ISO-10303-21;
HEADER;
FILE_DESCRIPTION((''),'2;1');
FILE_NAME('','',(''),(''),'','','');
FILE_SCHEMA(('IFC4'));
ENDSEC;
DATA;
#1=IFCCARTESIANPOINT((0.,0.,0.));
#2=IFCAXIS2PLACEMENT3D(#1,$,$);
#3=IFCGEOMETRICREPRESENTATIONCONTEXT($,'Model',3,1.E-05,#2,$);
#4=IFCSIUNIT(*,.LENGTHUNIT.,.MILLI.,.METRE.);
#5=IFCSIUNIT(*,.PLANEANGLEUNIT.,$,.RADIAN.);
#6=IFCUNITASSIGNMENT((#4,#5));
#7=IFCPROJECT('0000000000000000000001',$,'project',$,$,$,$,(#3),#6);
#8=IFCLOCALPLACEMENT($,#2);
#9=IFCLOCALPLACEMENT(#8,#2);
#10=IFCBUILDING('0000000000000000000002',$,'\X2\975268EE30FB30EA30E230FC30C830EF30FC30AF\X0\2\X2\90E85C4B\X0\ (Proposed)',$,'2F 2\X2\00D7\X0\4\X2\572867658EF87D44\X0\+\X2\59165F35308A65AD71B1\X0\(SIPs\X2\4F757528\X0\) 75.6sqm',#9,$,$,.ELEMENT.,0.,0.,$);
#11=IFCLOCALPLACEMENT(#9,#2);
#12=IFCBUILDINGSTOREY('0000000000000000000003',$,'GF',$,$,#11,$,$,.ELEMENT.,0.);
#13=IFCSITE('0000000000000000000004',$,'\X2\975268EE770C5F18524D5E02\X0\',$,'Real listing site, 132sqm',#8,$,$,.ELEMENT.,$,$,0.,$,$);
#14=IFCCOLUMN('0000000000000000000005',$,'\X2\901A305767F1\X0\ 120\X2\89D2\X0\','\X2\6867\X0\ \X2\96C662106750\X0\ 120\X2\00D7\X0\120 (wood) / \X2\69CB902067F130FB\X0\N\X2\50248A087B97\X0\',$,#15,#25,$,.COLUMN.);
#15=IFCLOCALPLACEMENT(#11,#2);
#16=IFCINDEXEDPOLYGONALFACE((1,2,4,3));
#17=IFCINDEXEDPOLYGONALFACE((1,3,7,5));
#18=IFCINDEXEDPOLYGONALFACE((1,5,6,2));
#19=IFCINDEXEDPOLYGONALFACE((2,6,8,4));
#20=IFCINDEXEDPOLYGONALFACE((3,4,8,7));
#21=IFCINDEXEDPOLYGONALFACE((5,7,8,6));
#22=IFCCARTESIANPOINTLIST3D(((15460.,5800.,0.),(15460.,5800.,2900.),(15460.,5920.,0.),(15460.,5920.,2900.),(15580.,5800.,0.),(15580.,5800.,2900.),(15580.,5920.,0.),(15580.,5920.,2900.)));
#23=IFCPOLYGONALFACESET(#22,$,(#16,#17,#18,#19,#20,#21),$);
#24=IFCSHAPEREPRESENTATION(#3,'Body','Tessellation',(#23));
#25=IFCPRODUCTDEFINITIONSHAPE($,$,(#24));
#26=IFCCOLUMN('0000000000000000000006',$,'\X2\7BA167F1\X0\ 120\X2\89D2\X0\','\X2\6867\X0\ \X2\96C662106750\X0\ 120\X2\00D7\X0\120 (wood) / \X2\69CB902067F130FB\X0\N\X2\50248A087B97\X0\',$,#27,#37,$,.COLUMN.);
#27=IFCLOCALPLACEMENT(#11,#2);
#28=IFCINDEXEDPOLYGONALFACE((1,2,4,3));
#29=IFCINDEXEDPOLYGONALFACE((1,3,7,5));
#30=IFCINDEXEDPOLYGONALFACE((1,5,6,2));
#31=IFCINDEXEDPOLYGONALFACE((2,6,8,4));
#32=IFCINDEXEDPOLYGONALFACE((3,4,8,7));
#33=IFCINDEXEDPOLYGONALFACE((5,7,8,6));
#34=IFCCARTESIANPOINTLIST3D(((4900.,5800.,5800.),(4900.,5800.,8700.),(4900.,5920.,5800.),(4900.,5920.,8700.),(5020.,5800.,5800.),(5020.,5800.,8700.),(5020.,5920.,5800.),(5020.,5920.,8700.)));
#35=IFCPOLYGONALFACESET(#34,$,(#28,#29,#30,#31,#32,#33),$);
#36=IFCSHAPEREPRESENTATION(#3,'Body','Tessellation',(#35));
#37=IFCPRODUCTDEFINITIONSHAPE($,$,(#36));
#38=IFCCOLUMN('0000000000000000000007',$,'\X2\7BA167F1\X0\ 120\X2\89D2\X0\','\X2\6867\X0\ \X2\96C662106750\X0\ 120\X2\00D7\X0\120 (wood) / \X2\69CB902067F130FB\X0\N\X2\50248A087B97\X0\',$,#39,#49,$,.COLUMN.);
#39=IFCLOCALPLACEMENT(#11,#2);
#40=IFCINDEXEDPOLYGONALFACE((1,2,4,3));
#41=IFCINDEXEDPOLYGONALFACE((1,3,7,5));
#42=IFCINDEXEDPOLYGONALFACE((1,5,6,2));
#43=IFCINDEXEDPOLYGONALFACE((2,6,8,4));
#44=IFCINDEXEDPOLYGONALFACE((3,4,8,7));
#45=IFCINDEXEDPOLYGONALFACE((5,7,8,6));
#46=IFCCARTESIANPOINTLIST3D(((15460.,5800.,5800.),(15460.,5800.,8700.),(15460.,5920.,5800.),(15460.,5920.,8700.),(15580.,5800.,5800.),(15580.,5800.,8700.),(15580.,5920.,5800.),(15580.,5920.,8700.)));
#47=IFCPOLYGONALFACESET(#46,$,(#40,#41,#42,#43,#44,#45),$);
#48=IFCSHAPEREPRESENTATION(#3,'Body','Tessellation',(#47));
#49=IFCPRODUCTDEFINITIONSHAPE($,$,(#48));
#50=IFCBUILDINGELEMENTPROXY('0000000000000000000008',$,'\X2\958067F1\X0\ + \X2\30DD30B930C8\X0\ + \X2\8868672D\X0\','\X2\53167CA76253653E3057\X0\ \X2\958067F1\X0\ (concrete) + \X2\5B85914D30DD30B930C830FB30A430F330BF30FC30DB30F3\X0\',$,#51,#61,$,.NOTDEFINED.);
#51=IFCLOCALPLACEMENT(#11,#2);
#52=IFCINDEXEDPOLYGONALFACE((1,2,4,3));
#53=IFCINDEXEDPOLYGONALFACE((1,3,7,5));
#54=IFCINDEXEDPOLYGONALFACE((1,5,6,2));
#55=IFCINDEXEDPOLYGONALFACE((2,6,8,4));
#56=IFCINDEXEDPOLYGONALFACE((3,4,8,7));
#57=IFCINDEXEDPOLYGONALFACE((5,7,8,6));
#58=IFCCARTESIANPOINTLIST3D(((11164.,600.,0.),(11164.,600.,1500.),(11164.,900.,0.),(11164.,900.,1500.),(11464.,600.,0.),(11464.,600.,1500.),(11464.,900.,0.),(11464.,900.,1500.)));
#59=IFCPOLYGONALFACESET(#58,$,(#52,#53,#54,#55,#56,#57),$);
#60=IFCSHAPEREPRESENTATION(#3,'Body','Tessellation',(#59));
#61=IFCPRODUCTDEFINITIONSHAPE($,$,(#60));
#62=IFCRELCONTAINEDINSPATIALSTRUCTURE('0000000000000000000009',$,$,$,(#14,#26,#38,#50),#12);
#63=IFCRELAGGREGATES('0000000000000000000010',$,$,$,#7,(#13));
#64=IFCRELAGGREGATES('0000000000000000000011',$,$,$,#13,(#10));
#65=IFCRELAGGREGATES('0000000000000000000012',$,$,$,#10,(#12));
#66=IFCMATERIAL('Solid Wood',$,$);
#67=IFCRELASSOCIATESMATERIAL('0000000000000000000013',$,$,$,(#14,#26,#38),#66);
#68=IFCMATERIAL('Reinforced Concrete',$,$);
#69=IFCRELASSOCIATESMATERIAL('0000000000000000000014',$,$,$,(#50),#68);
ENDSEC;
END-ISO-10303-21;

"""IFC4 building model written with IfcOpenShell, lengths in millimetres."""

from ifc_helpers import new_model, si_unit, frame, frame_2d, origin, place, context, project, spatial, rectangle, extrude, material, element, save


model = new_model("IFC4")

# Units and contexts
model_context = context("Model", 3, precision=1e-05, world=origin())
ifc_project = project(units=[si_unit("LENGTHUNIT", "METRE", prefix="MILLI"), si_unit("PLANEANGLEUNIT", "RADIAN")], contexts=[model_context])

# Site, building, storey
site_placement = place(None, origin())
site = spatial("IfcSite", under=ifc_project, at=site_placement, Name="青森県弘前市", ObjectType="Real listing site, 132sqm", CompositionType="ELEMENT", RefElevation=0.0)
building_placement = place(site_placement, origin())
building = spatial("IfcBuilding", under=site, at=building_placement, Name="青森・リモートワーク2部屋 (Proposed)", ObjectType="2F 2×4在来軸組+外張り断熱(SIPs併用) 75.6sqm", CompositionType="ELEMENT", ElevationOfRefHeight=0.0, ElevationOfTerrain=0.0)
storey_placement = place(building_placement, origin())
storey = spatial("IfcBuildingStorey", under=building, at=storey_placement, Name="GF", CompositionType="ELEMENT", Elevation=0.0)

# Columns
ifc_material_1 = material(Name="Solid Wood")
column_1_placement = place(storey_placement, frame((7730.0, 2900.0, 0.0)))
element("IfcColumn", 1, at=column_1_placement, inside=storey, material=ifc_material_1, Name="通し柱 120角", Description="桧 集成材 120×120 (wood) / 構造柱・N値計算", PredefinedType="COLUMN", context=model_context, shape_type="SweptSolid", body=[
    extrude(rectangle(XDim=120.0, YDim=120.0, at=frame_2d((60.0, 60.0))), frame((7730.0, 2900.0, 0.0)), (0.0, 0.0, 1.0), 2900.0),
])
column_2_placement = place(storey_placement, frame((2450.0, 2900.0, 2900.0)))
element("IfcColumn", 2, at=column_2_placement, inside=storey, material=ifc_material_1, Name="管柱 120角", Description="桧 集成材 120×120 (wood) / 構造柱・N値計算", PredefinedType="COLUMN", context=model_context, shape_type="SweptSolid", body=[
    extrude(rectangle(XDim=120.0, YDim=120.0, at=frame_2d((60.0, 60.0))), frame((2450.0, 2900.0, 2900.0)), (0.0, 0.0, 1.0), 2900.0),
])
column_3_placement = place(storey_placement, frame((7730.0, 2900.0, 2900.0)))
element("IfcColumn", 3, at=column_3_placement, inside=storey, material=ifc_material_1, Name="管柱 120角", Description="桧 集成材 120×120 (wood) / 構造柱・N値計算", PredefinedType="COLUMN", context=model_context, shape_type="SweptSolid", body=[
    extrude(rectangle(XDim=120.0, YDim=120.0, at=frame_2d((60.0, 60.0))), frame((7730.0, 2900.0, 2900.0)), (0.0, 0.0, 1.0), 2900.0),
])

# Shared definitions
ifc_material_2 = material(Name="Reinforced Concrete")

# Building element proxy
proxy_placement = place(storey_placement, frame((5582.0, 300.0, 0.0)))
element("IfcBuildingElementProxy", 4, at=proxy_placement, inside=storey, material=ifc_material_2, Name="門柱 + ポスト + 表札", Description="化粧打放し 門柱 (concrete) + 宅配ポスト・インターホン", PredefinedType="NOTDEFINED", context=model_context, shape_type="SweptSolid", body=[
    extrude(rectangle(XDim=300.0, YDim=300.0, at=frame_2d((150.0, 150.0))), frame((5582.0, 300.0, 0.0)), (0.0, 0.0, 1.0), 1500.0),
])

save(model, "model.ifc")
